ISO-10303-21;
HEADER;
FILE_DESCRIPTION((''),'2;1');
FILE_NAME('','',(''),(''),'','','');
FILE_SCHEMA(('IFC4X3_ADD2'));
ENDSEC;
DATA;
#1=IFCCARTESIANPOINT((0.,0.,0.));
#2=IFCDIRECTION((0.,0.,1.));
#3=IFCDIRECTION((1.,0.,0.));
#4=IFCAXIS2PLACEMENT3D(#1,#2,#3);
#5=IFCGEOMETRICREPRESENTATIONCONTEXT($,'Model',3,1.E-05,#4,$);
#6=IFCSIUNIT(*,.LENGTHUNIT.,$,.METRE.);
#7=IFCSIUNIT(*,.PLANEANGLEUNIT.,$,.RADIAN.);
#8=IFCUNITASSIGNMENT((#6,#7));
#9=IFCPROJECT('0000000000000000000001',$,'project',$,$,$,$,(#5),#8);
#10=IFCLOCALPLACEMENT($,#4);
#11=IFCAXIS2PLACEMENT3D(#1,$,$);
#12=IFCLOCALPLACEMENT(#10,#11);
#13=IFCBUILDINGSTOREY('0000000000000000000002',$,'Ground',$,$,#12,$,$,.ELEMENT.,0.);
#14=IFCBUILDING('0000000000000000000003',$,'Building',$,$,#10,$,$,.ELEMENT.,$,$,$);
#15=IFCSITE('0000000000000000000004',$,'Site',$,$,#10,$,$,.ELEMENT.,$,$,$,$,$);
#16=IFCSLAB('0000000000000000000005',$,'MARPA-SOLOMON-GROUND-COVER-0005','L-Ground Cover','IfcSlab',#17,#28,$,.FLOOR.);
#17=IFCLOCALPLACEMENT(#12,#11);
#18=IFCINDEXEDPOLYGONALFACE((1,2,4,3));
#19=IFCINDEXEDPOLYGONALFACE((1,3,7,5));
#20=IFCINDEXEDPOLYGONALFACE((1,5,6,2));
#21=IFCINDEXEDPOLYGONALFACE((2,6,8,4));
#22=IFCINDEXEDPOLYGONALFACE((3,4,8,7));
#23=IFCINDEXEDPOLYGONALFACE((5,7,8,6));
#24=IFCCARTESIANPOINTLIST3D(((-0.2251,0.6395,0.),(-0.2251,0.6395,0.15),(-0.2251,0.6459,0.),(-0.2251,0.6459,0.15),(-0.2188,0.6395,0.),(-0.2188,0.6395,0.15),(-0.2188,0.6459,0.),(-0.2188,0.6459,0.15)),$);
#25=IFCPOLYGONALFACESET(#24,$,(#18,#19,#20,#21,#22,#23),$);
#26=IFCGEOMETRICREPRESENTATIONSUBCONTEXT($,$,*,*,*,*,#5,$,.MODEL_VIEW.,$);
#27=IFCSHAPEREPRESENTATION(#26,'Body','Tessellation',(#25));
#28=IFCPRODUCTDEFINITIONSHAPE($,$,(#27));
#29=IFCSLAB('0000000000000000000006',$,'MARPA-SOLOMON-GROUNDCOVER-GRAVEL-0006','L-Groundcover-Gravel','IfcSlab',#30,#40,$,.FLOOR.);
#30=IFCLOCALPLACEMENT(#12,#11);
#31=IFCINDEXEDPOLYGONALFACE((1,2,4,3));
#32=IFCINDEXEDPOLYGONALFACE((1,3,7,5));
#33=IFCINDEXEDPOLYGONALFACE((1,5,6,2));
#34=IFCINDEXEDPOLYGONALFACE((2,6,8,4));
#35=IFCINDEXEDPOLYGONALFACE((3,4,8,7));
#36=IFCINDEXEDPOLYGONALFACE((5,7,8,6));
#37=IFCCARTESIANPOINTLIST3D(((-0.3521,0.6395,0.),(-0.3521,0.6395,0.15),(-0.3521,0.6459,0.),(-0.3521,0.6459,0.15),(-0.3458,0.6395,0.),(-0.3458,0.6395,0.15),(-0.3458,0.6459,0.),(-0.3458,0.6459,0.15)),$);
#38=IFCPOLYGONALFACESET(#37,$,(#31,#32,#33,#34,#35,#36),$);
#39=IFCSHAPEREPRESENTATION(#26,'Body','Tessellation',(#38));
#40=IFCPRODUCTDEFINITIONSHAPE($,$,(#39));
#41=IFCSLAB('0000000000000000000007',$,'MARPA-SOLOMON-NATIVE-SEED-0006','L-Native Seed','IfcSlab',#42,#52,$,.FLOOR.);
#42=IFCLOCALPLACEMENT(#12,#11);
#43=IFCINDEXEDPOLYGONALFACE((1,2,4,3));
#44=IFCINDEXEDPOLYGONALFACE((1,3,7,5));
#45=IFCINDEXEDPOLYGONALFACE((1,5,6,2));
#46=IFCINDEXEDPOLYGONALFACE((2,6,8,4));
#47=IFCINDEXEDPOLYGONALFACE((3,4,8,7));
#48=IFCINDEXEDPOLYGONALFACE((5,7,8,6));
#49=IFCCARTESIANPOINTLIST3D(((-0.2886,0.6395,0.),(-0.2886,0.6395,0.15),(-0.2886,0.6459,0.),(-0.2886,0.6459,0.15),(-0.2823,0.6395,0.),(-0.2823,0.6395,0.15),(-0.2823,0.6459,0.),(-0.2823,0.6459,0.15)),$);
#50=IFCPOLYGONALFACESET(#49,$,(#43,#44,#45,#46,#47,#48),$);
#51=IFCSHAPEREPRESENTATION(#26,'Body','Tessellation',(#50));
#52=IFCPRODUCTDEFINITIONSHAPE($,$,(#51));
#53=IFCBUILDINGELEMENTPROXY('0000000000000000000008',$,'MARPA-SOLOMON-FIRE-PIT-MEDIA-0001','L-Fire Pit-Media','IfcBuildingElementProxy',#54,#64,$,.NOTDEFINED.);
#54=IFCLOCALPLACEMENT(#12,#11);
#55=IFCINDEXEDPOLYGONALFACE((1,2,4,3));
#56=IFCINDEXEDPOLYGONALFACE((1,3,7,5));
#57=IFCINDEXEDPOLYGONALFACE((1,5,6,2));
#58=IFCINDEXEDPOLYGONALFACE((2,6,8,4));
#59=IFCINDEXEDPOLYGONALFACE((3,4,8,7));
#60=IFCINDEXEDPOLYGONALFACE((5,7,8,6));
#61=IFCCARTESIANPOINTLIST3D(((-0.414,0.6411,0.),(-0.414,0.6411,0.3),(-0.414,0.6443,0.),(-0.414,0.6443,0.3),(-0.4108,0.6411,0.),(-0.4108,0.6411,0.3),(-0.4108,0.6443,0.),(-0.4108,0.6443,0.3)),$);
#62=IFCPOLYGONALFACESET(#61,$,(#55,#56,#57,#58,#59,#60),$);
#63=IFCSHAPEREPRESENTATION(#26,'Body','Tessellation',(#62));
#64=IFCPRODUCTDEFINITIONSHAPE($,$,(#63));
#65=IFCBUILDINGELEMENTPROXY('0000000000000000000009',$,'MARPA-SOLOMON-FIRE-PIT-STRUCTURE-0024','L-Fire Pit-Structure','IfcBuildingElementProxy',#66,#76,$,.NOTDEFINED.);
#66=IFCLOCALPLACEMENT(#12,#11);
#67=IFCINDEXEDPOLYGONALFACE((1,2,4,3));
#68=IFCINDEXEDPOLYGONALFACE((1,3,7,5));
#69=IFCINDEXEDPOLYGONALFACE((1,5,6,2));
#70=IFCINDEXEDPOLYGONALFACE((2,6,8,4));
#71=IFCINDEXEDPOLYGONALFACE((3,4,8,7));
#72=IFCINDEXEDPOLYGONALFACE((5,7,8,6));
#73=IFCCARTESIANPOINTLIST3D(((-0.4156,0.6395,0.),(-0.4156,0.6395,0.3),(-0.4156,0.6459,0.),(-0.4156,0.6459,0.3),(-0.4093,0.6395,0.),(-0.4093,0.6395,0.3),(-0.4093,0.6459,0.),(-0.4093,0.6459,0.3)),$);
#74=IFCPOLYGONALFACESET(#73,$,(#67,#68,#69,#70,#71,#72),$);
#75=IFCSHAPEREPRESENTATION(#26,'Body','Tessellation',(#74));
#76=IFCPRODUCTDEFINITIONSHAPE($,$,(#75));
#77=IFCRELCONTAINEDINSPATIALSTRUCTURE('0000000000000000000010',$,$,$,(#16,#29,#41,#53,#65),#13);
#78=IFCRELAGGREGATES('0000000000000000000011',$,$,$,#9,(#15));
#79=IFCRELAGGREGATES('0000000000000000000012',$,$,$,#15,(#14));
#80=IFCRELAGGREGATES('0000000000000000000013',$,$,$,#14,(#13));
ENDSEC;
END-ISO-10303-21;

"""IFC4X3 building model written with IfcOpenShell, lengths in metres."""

from ifc_helpers import new_model, si_unit, frame, origin, origin_with_axes, place, context, subcontext, project, spatial, polyline, outline, extrude, element, save


model = new_model("IFC4X3")

# Units and contexts
model_context = context("Model", 3, precision=1e-05, world=origin_with_axes())
sub_context = subcontext(model_context, None, None, "MODEL_VIEW")
ifc_project = project(units=[si_unit("LENGTHUNIT", "METRE"), si_unit("PLANEANGLEUNIT", "RADIAN")], contexts=[model_context])

# Site, building, storey
placement = place(None, origin_with_axes())
site = spatial("IfcSite", under=ifc_project, at=placement, Name="Site", CompositionType="ELEMENT")
building = spatial("IfcBuilding", under=site, at=placement, Name="Building", CompositionType="ELEMENT")
storey_placement = place(placement, origin())
storey = spatial("IfcBuildingStorey", under=building, at=storey_placement, Name="Ground", CompositionType="ELEMENT", Elevation=0.0)

# Slabs
for number, where, name, description in (
    (1, (-0.2251, 0.6395, 0.0), "MARPA-SOLOMON-GROUND-COVER-0005", "L-Ground Cover"),
    (2, (-0.3521, 0.6395, 0.0), "MARPA-SOLOMON-GROUNDCOVER-GRAVEL-0006", "L-Groundcover-Gravel"),
    (3, (-0.2886, 0.6395, 0.0), "MARPA-SOLOMON-NATIVE-SEED-0006", "L-Native Seed"),
):
    element("IfcSlab", number, at=place(storey_placement, frame(where)), inside=storey, Name=name, Description=description, ObjectType="IfcSlab", PredefinedType="FLOOR", context=sub_context, shape_type="SweptSolid", body=[
        extrude(outline(polyline([(0.0, 0.0063), (0.0063, 0.0063), (0.0063, 0.0), (0.0, 0.0), (0.0, 0.0063)])), origin(), (0.0, 0.0, 1.0), 0.15),
    ])

# Building element proxies
for number, where, name in (
    (4, (-0.414, 0.6411, 0.0), "MARPA-SOLOMON-FIRE-PIT-MEDIA-0001"),
):
    element("IfcBuildingElementProxy", number, at=place(placement, frame(where)), inside=storey, Name=name, Description="L-Fire Pit-Media", ObjectType="IfcBuildingElementProxy", PredefinedType="NOTDEFINED", context=sub_context, shape_type="SweptSolid", body=[
        extrude(outline(polyline([(0.0, 0.0032), (0.0032, 0.0032), (0.0032, 0.0), (0.0, 0.0), (0.0, 0.0032)])), origin(), (0.0, 0.0, 1.0), 0.3),
    ])
proxy_placement = place(placement, frame((-0.4156, 0.6395, 0.0)))
element("IfcBuildingElementProxy", 5, at=proxy_placement, inside=storey, Name="MARPA-SOLOMON-FIRE-PIT-STRUCTURE-0024", Description="L-Fire Pit-Structure", ObjectType="IfcBuildingElementProxy", PredefinedType="NOTDEFINED", context=sub_context, shape_type="SweptSolid", body=[
    extrude(outline(polyline([(0.0, 0.0063), (0.0063, 0.0063), (0.0063, 0.0), (0.0, 0.0), (0.0, 0.0063)])), origin(), (0.0, 0.0, 1.0), 0.3),
])

save(model, "model.ifc")
